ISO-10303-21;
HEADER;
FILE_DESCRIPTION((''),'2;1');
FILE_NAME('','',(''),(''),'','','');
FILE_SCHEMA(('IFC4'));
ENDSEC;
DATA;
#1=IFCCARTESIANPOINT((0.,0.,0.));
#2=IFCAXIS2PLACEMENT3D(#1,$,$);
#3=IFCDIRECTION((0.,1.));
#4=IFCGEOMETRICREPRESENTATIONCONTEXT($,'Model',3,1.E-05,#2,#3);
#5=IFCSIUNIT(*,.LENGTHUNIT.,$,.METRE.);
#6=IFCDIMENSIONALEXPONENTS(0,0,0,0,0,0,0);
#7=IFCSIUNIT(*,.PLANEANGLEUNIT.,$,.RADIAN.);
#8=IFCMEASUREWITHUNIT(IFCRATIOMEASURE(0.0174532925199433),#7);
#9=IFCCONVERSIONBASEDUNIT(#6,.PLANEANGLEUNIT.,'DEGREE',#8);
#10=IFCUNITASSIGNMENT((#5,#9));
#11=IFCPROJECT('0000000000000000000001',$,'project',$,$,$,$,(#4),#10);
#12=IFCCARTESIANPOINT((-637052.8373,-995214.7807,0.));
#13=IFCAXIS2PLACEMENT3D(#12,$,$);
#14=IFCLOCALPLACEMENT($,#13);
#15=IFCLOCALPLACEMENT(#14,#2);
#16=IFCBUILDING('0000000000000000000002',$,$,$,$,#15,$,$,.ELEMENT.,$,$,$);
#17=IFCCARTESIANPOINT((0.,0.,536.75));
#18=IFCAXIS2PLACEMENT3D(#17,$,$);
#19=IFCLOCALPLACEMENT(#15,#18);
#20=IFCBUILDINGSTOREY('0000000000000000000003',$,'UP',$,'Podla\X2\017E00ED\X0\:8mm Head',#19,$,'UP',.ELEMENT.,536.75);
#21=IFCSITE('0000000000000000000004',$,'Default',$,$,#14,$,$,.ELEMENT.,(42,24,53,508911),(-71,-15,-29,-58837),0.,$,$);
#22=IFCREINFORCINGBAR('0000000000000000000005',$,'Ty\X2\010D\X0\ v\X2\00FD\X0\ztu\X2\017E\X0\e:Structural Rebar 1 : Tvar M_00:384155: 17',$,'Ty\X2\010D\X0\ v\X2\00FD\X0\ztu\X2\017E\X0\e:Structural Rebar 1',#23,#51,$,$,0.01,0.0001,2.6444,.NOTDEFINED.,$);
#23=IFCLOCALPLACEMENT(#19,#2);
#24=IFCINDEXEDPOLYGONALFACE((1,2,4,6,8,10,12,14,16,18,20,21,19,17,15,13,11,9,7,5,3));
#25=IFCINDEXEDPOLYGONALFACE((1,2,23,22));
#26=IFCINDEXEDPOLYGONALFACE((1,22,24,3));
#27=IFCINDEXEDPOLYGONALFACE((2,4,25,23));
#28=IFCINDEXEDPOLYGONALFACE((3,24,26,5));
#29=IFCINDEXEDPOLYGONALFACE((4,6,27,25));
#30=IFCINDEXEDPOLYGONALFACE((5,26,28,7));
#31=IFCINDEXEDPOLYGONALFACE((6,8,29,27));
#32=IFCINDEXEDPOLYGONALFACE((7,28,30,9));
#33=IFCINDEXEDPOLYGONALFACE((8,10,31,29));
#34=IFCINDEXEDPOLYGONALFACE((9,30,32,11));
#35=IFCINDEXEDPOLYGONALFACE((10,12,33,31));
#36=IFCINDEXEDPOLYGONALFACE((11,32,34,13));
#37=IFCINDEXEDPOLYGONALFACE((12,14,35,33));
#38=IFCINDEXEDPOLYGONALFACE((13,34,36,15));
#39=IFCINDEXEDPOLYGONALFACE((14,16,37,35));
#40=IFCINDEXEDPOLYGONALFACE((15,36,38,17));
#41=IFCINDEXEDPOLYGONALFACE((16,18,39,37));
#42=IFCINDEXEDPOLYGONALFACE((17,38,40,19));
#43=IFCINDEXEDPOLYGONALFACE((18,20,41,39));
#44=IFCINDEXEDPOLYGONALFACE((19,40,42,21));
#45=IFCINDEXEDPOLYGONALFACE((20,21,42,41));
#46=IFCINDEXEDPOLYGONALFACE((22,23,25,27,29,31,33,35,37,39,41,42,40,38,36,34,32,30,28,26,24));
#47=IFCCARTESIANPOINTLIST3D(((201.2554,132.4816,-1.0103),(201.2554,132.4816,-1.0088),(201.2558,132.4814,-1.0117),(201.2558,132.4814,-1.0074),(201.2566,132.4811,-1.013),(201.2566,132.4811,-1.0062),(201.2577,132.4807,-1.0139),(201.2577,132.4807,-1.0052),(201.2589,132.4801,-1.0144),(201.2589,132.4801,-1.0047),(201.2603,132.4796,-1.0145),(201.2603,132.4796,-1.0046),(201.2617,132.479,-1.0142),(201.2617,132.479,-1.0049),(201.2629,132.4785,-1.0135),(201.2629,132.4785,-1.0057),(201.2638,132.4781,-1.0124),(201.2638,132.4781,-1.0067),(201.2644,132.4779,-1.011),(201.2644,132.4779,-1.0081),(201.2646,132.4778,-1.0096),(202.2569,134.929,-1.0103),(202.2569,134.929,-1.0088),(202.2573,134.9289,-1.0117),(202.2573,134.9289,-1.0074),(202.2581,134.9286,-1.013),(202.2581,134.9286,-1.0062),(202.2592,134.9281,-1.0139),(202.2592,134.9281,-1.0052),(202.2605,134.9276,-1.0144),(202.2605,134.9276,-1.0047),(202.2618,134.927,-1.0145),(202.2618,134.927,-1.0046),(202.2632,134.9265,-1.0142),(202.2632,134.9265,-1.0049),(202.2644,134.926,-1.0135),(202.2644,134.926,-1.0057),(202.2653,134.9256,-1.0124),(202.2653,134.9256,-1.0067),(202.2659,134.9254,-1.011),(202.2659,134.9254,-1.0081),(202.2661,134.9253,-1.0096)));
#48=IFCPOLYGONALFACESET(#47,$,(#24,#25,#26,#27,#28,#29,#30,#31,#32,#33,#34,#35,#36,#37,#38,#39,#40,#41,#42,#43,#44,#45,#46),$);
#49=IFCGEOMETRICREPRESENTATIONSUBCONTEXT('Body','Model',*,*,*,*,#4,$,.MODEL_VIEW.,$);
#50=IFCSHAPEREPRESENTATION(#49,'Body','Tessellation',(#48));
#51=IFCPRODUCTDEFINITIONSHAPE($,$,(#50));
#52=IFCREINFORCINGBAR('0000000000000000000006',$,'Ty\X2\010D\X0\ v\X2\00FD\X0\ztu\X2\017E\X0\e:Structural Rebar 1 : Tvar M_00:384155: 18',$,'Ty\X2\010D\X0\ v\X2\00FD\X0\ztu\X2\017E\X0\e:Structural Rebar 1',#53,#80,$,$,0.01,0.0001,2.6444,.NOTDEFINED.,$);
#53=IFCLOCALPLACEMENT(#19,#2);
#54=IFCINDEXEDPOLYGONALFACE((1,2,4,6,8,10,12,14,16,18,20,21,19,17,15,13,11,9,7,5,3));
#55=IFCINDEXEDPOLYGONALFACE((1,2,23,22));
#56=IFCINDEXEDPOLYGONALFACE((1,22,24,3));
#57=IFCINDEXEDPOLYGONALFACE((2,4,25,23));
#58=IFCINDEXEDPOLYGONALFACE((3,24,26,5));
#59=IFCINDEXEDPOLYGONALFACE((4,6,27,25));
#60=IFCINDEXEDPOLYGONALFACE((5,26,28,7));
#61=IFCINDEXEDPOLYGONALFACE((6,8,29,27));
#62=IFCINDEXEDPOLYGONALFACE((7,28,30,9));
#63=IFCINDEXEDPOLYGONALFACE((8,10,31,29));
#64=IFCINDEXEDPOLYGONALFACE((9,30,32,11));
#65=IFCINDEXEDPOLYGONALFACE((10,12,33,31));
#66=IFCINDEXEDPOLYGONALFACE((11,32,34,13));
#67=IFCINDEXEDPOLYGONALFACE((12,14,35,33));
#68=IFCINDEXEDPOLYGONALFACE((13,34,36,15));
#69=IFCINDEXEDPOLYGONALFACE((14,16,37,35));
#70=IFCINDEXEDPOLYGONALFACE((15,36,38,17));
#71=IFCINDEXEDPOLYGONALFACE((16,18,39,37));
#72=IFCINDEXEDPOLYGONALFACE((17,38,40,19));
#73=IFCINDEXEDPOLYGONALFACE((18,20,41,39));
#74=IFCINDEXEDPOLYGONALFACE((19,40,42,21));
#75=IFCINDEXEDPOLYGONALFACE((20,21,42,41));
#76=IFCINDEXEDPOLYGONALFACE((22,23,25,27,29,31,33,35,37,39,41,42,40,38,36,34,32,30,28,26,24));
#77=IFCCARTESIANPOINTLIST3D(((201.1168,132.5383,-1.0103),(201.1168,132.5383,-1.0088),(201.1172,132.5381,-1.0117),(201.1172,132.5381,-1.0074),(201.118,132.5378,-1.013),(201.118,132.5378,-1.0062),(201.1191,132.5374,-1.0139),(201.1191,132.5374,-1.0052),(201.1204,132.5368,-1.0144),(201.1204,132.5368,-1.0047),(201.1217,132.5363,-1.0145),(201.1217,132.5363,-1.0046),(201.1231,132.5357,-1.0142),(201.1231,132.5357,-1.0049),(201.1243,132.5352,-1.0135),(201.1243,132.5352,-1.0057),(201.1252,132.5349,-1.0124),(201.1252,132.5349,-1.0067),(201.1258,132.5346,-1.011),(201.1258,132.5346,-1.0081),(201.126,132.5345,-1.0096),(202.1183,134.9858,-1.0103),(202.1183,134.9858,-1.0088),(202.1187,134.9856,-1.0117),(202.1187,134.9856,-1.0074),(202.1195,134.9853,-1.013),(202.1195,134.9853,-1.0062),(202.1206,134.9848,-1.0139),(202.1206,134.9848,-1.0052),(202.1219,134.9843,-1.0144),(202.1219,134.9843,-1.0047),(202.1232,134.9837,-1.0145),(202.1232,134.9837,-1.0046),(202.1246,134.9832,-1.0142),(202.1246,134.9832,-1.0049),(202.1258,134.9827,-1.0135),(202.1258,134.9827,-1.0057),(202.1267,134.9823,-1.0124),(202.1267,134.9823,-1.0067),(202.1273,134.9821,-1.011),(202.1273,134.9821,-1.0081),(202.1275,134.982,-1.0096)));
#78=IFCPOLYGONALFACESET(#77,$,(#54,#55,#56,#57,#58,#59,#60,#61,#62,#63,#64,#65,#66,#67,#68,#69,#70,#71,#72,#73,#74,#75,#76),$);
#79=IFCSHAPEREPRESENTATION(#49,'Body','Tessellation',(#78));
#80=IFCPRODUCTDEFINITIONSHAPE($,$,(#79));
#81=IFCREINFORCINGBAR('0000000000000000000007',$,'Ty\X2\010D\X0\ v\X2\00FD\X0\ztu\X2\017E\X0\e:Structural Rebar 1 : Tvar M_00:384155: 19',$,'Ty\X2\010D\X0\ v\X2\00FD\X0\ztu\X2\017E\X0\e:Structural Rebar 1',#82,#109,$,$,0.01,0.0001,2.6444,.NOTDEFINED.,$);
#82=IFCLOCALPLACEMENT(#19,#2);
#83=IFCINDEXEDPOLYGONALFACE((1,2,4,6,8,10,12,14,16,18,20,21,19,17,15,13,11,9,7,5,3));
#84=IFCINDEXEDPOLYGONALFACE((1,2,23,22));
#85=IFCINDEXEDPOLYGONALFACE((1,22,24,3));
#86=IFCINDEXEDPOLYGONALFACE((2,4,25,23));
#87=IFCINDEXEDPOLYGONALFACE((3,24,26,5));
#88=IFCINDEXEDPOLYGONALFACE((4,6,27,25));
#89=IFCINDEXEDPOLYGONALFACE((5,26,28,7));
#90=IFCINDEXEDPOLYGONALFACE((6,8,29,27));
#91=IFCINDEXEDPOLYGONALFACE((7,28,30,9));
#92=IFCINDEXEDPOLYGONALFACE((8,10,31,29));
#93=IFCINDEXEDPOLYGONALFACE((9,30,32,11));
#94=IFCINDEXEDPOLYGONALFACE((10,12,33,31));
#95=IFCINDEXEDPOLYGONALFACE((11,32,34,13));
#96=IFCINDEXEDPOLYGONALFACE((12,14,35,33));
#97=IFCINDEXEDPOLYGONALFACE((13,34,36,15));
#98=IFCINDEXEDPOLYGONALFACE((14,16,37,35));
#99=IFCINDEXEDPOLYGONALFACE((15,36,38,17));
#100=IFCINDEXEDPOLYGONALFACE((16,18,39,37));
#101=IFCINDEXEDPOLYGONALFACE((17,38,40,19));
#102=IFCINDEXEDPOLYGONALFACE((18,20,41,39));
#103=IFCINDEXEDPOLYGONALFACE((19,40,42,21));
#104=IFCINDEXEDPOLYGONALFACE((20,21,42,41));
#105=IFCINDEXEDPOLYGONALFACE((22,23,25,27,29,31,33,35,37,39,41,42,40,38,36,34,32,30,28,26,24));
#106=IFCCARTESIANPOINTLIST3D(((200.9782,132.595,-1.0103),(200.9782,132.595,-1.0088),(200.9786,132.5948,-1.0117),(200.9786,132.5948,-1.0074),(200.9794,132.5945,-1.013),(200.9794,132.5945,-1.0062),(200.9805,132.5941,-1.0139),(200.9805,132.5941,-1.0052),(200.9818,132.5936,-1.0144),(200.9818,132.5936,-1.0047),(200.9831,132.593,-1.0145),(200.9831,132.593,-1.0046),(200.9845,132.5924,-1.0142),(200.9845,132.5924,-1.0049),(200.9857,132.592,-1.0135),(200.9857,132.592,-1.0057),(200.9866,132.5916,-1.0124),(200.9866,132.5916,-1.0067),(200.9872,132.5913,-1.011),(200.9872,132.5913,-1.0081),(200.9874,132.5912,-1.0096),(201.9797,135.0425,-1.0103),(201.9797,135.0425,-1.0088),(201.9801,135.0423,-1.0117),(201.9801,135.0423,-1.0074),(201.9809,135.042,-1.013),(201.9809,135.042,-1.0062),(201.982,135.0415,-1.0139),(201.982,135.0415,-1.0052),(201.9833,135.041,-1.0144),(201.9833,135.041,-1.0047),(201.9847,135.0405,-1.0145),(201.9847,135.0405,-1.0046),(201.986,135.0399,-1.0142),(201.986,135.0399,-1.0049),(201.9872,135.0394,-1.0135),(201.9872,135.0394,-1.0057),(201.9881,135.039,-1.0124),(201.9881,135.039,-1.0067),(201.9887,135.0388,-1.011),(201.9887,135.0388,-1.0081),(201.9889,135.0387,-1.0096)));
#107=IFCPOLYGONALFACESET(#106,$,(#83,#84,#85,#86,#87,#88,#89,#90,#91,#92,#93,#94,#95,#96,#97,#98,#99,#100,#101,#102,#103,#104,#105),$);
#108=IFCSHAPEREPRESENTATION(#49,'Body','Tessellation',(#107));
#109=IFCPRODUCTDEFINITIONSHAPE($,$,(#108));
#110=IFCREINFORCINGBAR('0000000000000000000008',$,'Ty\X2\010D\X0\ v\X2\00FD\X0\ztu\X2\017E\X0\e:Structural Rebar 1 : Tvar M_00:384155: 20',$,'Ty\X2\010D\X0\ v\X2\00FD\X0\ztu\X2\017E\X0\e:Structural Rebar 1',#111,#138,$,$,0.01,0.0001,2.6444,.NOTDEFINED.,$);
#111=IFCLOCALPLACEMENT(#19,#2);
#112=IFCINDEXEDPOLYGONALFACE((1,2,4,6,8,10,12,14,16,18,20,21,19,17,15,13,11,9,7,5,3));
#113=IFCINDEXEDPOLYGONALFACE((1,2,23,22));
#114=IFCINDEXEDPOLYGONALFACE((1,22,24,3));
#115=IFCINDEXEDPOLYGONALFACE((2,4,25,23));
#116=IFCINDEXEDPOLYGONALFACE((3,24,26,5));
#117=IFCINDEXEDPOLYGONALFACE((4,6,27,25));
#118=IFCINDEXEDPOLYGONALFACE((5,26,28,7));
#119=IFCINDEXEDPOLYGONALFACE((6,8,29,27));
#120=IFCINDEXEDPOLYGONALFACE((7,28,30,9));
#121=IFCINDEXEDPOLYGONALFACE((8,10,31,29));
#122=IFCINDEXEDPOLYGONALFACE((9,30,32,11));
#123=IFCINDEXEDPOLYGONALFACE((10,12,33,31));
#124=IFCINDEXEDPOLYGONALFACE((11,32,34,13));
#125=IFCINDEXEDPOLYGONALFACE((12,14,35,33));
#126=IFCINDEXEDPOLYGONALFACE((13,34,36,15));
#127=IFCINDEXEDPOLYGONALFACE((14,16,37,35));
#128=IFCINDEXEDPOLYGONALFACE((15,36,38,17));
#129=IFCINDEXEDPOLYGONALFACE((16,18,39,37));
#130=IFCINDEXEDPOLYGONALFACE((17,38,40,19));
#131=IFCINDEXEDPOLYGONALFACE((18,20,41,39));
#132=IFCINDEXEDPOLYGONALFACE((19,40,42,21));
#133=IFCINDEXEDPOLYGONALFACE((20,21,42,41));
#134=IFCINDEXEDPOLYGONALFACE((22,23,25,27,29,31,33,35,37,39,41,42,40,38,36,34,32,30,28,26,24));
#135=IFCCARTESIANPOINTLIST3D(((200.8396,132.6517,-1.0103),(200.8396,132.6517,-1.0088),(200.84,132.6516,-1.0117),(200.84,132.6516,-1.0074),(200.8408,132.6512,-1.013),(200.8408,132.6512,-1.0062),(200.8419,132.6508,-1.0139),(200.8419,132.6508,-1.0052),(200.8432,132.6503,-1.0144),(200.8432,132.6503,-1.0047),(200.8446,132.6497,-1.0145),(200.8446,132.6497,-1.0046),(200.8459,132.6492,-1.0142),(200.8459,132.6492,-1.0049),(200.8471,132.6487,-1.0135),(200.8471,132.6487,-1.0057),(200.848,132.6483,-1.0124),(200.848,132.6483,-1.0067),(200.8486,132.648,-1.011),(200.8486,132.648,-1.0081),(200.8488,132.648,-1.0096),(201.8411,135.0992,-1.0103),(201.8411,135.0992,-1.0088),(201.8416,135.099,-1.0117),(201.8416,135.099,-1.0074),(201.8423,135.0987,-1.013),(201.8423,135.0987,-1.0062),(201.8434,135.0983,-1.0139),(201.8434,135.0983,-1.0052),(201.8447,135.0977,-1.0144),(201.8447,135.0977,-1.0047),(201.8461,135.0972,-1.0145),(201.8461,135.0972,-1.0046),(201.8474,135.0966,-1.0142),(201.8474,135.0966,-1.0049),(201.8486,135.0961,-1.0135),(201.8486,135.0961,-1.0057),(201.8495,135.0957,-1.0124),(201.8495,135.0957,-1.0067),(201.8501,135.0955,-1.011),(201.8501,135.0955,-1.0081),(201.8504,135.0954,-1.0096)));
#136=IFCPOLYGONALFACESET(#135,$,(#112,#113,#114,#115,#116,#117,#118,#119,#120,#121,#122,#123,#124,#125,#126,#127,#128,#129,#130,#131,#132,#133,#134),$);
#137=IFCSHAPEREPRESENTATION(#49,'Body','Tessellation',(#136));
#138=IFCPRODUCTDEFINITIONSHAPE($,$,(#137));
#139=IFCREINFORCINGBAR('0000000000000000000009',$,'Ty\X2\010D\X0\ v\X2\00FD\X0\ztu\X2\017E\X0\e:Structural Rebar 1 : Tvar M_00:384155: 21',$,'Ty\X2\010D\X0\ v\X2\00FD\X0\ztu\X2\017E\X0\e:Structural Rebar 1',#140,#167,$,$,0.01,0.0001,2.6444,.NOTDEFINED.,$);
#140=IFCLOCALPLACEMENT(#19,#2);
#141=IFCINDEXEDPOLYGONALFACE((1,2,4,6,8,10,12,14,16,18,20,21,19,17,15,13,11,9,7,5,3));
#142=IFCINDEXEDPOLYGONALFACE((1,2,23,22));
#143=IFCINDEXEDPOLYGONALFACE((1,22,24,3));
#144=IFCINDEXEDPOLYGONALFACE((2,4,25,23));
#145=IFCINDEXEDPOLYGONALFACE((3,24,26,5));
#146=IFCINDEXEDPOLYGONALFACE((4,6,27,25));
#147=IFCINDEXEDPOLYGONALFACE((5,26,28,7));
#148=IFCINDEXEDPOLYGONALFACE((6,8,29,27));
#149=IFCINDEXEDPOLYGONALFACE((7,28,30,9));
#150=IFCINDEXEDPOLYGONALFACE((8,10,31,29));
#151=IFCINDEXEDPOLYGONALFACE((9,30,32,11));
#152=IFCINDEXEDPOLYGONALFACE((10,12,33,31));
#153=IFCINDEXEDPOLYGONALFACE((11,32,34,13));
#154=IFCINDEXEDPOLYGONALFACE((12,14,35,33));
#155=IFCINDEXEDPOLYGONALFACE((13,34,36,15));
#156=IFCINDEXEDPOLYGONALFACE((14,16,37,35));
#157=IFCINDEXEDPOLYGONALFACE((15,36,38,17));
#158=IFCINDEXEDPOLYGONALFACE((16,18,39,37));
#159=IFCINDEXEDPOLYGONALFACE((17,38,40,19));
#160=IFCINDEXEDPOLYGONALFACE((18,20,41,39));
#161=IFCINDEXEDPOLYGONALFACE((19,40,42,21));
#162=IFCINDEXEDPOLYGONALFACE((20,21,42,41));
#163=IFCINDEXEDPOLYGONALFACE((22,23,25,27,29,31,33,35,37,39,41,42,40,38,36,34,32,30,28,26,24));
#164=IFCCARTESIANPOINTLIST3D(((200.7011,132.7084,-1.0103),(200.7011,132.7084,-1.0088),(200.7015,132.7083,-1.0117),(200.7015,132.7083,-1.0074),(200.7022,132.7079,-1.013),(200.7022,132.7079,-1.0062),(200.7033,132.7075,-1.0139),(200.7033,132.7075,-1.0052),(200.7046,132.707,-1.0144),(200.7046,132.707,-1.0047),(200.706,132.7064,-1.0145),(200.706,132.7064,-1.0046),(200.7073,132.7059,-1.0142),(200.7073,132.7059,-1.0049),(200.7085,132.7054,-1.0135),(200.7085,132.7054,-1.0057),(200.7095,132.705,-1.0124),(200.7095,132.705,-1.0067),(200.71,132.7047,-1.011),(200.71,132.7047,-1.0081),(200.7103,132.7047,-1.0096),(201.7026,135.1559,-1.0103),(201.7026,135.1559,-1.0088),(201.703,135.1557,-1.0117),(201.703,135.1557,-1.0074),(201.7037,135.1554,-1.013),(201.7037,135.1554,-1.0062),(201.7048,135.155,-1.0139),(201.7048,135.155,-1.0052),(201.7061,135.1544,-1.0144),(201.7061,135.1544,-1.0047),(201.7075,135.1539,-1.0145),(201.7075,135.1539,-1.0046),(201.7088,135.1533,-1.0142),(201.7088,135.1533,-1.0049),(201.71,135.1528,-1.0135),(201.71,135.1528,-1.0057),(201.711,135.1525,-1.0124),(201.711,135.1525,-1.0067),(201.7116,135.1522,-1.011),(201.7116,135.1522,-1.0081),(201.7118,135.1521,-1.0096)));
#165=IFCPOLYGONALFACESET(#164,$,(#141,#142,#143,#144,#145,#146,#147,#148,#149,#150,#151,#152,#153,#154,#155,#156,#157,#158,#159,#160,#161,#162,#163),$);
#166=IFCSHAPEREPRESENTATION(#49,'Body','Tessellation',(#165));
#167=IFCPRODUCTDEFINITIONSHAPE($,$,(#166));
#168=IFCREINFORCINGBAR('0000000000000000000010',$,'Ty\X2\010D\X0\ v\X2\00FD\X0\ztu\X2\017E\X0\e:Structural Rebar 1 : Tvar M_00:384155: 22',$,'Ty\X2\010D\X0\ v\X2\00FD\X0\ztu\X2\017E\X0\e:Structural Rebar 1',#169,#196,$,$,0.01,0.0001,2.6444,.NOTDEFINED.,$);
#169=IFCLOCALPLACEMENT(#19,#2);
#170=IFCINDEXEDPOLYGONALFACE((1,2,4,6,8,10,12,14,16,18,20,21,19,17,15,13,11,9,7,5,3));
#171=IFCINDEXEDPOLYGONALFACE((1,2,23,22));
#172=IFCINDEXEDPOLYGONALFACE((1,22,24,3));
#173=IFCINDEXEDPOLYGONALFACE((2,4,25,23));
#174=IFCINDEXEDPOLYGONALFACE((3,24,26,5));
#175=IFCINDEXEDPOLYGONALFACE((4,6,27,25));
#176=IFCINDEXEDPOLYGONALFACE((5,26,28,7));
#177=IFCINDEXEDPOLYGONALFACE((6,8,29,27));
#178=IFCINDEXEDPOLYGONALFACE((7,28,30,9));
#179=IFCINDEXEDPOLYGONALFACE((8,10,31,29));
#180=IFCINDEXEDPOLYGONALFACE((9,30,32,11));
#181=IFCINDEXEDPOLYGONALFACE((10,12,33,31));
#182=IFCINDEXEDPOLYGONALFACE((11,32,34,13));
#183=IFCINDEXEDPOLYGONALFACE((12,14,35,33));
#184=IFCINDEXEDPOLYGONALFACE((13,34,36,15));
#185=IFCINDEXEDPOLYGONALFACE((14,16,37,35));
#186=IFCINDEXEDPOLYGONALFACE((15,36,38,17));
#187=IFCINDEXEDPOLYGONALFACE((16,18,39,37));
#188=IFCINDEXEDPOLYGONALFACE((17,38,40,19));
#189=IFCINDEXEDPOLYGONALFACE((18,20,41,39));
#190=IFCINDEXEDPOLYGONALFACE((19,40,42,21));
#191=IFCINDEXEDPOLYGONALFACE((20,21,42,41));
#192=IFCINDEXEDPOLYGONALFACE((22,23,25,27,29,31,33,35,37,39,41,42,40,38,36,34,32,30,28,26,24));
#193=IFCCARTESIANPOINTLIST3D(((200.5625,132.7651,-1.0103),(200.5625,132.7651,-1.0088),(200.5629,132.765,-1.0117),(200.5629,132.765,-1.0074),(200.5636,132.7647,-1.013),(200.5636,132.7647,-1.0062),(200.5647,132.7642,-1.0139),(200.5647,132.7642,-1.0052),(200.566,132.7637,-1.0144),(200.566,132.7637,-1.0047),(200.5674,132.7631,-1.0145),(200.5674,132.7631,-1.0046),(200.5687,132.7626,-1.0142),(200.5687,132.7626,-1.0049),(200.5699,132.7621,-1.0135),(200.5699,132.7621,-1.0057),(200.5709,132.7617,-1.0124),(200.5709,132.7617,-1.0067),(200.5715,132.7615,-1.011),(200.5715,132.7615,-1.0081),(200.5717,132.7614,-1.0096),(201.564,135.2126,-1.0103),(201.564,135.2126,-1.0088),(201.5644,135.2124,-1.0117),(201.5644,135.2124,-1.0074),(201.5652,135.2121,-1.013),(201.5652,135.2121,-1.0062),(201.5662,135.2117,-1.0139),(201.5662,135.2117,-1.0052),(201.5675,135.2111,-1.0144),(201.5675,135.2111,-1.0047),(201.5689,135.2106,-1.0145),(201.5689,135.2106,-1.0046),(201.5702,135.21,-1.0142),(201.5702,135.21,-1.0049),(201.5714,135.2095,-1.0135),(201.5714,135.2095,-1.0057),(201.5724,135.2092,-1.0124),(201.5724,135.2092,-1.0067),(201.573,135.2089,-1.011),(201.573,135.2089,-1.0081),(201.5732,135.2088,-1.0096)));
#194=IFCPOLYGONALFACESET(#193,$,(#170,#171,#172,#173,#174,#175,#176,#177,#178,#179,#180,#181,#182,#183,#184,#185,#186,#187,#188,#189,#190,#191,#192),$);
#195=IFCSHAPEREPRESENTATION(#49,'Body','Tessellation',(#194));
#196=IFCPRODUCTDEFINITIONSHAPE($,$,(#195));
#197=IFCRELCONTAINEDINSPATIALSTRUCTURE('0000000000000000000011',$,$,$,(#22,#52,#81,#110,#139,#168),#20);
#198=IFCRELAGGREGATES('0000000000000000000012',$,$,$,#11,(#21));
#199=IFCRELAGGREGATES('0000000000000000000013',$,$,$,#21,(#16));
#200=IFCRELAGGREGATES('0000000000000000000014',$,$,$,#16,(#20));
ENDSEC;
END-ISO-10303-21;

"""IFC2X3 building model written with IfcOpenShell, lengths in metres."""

from ifc_helpers import new_model, entity, si_unit, converted_unit, direction, frame, origin, place, context, subcontext, project, spatial, element, save


model = new_model("IFC2X3")

# Units and contexts
model_context = context("Model", 3, precision=1e-05, world=origin(), true_north=direction((0.0, 1.0)))
body_context = subcontext(model_context, "Body", "Model", "MODEL_VIEW")
ifc_project = project(units=[si_unit("LENGTHUNIT", "METRE"), converted_unit("PLANEANGLEUNIT", "DEGREE", entity("IfcRatioMeasure", 0.0174532925199433), si_unit("PLANEANGLEUNIT", "RADIAN"), dimensions=[0, 0, 0, 0, 0, 0, 0])], contexts=[model_context])

# Site, building, storey
site_placement = place(None, frame((-637052.8373, -995214.7807, 0.0)))
site = spatial("IfcSite", under=ifc_project, at=site_placement, Name="Default", CompositionType="ELEMENT", RefLatitude=(42, 24, 53, 508911), RefLongitude=(-71, -15, -29, -58837), RefElevation=0.0)
building_placement = place(site_placement, origin())
building = spatial("IfcBuilding", under=site, at=building_placement, CompositionType="ELEMENT")
storey_placement = place(building_placement, frame((0.0, 0.0, 536.75)))
storey = spatial("IfcBuildingStorey", under=building, at=storey_placement, Name="UP", ObjectType="Podlaží:8mm Head", LongName="UP", CompositionType="ELEMENT", Elevation=536.75)

# Reinforcing bars
reinforcing_bar_1_placement = place(storey_placement, origin())
element("IfcReinforcingBar", 1, at=reinforcing_bar_1_placement, inside=storey, Name="Tyč výztuže:Structural Rebar 1 : Tvar M_00:384155: 17", ObjectType="Tyč výztuže:Structural Rebar 1", BarLength=2.6444, BarRole="NOTDEFINED", CrossSectionArea=0.0001, NominalDiameter=0.01, context=body_context, shape_type="AdvancedSweptSolid", body=[
    entity("IfcSweptDiskSolid", entity("IfcCompositeCurve", [entity("IfcCompositeCurveSegment", "CONTINUOUS", True, entity("IfcPolyline", [entity("IfcCartesianPoint", [-202.2615, -134.9272, 1.0096]), entity("IfcCartesianPoint", [-201.26, -132.4797, 1.0096])]))], False), 0.005, None, 0.0, 1.0),
])
reinforcing_bar_2_placement = place(storey_placement, origin())
element("IfcReinforcingBar", 2, at=reinforcing_bar_2_placement, inside=storey, Name="Tyč výztuže:Structural Rebar 1 : Tvar M_00:384155: 18", ObjectType="Tyč výztuže:Structural Rebar 1", BarLength=2.6444, BarRole="NOTDEFINED", CrossSectionArea=0.0001, NominalDiameter=0.01, context=body_context, shape_type="AdvancedSweptSolid", body=[
    entity("IfcSweptDiskSolid", entity("IfcCompositeCurve", [entity("IfcCompositeCurveSegment", "CONTINUOUS", True, entity("IfcPolyline", [entity("IfcCartesianPoint", [-202.1229, -134.9839, 1.0096]), entity("IfcCartesianPoint", [-201.1214, -132.5364, 1.0096])]))], False), 0.005, None, 0.0, 1.0),
])
reinforcing_bar_3_placement = place(storey_placement, origin())
element("IfcReinforcingBar", 3, at=reinforcing_bar_3_placement, inside=storey, Name="Tyč výztuže:Structural Rebar 1 : Tvar M_00:384155: 19", ObjectType="Tyč výztuže:Structural Rebar 1", BarLength=2.6444, BarRole="NOTDEFINED", CrossSectionArea=0.0001, NominalDiameter=0.01, context=body_context, shape_type="AdvancedSweptSolid", body=[
    entity("IfcSweptDiskSolid", entity("IfcCompositeCurve", [entity("IfcCompositeCurveSegment", "CONTINUOUS", True, entity("IfcPolyline", [entity("IfcCartesianPoint", [-201.9843, -135.0406, 1.0096]), entity("IfcCartesianPoint", [-200.9828, -132.5931, 1.0096])]))], False), 0.005, None, 0.0, 1.0),
])
reinforcing_bar_4_placement = place(storey_placement, origin())
element("IfcReinforcingBar", 4, at=reinforcing_bar_4_placement, inside=storey, Name="Tyč výztuže:Structural Rebar 1 : Tvar M_00:384155: 20", ObjectType="Tyč výztuže:Structural Rebar 1", BarLength=2.6444, BarRole="NOTDEFINED", CrossSectionArea=0.0001, NominalDiameter=0.01, context=body_context, shape_type="AdvancedSweptSolid", body=[
    entity("IfcSweptDiskSolid", entity("IfcCompositeCurve", [entity("IfcCompositeCurveSegment", "CONTINUOUS", True, entity("IfcPolyline", [entity("IfcCartesianPoint", [-201.8457, -135.0973, 1.0096]), entity("IfcCartesianPoint", [-200.8442, -132.6498, 1.0096])]))], False), 0.005, None, 0.0, 1.0),
])
reinforcing_bar_5_placement = place(storey_placement, origin())
element("IfcReinforcingBar", 5, at=reinforcing_bar_5_placement, inside=storey, Name="Tyč výztuže:Structural Rebar 1 : Tvar M_00:384155: 21", ObjectType="Tyč výztuže:Structural Rebar 1", BarLength=2.6444, BarRole="NOTDEFINED", CrossSectionArea=0.0001, NominalDiameter=0.01, context=body_context, shape_type="AdvancedSweptSolid", body=[
    entity("IfcSweptDiskSolid", entity("IfcCompositeCurve", [entity("IfcCompositeCurveSegment", "CONTINUOUS", True, entity("IfcPolyline", [entity("IfcCartesianPoint", [-201.7071, -135.154, 1.0096]), entity("IfcCartesianPoint", [-200.7056, -132.7066, 1.0096])]))], False), 0.005, None, 0.0, 1.0),
])
reinforcing_bar_6_placement = place(storey_placement, origin())
element("IfcReinforcingBar", 6, at=reinforcing_bar_6_placement, inside=storey, Name="Tyč výztuže:Structural Rebar 1 : Tvar M_00:384155: 22", ObjectType="Tyč výztuže:Structural Rebar 1", BarLength=2.6444, BarRole="NOTDEFINED", CrossSectionArea=0.0001, NominalDiameter=0.01, context=body_context, shape_type="AdvancedSweptSolid", body=[
    entity("IfcSweptDiskSolid", entity("IfcCompositeCurve", [entity("IfcCompositeCurveSegment", "CONTINUOUS", True, entity("IfcPolyline", [entity("IfcCartesianPoint", [-201.5686, -135.2107, 1.0096]), entity("IfcCartesianPoint", [-200.567, -132.7633, 1.0096])]))], False), 0.005, None, 0.0, 1.0),
])

save(model, "model.ifc")
